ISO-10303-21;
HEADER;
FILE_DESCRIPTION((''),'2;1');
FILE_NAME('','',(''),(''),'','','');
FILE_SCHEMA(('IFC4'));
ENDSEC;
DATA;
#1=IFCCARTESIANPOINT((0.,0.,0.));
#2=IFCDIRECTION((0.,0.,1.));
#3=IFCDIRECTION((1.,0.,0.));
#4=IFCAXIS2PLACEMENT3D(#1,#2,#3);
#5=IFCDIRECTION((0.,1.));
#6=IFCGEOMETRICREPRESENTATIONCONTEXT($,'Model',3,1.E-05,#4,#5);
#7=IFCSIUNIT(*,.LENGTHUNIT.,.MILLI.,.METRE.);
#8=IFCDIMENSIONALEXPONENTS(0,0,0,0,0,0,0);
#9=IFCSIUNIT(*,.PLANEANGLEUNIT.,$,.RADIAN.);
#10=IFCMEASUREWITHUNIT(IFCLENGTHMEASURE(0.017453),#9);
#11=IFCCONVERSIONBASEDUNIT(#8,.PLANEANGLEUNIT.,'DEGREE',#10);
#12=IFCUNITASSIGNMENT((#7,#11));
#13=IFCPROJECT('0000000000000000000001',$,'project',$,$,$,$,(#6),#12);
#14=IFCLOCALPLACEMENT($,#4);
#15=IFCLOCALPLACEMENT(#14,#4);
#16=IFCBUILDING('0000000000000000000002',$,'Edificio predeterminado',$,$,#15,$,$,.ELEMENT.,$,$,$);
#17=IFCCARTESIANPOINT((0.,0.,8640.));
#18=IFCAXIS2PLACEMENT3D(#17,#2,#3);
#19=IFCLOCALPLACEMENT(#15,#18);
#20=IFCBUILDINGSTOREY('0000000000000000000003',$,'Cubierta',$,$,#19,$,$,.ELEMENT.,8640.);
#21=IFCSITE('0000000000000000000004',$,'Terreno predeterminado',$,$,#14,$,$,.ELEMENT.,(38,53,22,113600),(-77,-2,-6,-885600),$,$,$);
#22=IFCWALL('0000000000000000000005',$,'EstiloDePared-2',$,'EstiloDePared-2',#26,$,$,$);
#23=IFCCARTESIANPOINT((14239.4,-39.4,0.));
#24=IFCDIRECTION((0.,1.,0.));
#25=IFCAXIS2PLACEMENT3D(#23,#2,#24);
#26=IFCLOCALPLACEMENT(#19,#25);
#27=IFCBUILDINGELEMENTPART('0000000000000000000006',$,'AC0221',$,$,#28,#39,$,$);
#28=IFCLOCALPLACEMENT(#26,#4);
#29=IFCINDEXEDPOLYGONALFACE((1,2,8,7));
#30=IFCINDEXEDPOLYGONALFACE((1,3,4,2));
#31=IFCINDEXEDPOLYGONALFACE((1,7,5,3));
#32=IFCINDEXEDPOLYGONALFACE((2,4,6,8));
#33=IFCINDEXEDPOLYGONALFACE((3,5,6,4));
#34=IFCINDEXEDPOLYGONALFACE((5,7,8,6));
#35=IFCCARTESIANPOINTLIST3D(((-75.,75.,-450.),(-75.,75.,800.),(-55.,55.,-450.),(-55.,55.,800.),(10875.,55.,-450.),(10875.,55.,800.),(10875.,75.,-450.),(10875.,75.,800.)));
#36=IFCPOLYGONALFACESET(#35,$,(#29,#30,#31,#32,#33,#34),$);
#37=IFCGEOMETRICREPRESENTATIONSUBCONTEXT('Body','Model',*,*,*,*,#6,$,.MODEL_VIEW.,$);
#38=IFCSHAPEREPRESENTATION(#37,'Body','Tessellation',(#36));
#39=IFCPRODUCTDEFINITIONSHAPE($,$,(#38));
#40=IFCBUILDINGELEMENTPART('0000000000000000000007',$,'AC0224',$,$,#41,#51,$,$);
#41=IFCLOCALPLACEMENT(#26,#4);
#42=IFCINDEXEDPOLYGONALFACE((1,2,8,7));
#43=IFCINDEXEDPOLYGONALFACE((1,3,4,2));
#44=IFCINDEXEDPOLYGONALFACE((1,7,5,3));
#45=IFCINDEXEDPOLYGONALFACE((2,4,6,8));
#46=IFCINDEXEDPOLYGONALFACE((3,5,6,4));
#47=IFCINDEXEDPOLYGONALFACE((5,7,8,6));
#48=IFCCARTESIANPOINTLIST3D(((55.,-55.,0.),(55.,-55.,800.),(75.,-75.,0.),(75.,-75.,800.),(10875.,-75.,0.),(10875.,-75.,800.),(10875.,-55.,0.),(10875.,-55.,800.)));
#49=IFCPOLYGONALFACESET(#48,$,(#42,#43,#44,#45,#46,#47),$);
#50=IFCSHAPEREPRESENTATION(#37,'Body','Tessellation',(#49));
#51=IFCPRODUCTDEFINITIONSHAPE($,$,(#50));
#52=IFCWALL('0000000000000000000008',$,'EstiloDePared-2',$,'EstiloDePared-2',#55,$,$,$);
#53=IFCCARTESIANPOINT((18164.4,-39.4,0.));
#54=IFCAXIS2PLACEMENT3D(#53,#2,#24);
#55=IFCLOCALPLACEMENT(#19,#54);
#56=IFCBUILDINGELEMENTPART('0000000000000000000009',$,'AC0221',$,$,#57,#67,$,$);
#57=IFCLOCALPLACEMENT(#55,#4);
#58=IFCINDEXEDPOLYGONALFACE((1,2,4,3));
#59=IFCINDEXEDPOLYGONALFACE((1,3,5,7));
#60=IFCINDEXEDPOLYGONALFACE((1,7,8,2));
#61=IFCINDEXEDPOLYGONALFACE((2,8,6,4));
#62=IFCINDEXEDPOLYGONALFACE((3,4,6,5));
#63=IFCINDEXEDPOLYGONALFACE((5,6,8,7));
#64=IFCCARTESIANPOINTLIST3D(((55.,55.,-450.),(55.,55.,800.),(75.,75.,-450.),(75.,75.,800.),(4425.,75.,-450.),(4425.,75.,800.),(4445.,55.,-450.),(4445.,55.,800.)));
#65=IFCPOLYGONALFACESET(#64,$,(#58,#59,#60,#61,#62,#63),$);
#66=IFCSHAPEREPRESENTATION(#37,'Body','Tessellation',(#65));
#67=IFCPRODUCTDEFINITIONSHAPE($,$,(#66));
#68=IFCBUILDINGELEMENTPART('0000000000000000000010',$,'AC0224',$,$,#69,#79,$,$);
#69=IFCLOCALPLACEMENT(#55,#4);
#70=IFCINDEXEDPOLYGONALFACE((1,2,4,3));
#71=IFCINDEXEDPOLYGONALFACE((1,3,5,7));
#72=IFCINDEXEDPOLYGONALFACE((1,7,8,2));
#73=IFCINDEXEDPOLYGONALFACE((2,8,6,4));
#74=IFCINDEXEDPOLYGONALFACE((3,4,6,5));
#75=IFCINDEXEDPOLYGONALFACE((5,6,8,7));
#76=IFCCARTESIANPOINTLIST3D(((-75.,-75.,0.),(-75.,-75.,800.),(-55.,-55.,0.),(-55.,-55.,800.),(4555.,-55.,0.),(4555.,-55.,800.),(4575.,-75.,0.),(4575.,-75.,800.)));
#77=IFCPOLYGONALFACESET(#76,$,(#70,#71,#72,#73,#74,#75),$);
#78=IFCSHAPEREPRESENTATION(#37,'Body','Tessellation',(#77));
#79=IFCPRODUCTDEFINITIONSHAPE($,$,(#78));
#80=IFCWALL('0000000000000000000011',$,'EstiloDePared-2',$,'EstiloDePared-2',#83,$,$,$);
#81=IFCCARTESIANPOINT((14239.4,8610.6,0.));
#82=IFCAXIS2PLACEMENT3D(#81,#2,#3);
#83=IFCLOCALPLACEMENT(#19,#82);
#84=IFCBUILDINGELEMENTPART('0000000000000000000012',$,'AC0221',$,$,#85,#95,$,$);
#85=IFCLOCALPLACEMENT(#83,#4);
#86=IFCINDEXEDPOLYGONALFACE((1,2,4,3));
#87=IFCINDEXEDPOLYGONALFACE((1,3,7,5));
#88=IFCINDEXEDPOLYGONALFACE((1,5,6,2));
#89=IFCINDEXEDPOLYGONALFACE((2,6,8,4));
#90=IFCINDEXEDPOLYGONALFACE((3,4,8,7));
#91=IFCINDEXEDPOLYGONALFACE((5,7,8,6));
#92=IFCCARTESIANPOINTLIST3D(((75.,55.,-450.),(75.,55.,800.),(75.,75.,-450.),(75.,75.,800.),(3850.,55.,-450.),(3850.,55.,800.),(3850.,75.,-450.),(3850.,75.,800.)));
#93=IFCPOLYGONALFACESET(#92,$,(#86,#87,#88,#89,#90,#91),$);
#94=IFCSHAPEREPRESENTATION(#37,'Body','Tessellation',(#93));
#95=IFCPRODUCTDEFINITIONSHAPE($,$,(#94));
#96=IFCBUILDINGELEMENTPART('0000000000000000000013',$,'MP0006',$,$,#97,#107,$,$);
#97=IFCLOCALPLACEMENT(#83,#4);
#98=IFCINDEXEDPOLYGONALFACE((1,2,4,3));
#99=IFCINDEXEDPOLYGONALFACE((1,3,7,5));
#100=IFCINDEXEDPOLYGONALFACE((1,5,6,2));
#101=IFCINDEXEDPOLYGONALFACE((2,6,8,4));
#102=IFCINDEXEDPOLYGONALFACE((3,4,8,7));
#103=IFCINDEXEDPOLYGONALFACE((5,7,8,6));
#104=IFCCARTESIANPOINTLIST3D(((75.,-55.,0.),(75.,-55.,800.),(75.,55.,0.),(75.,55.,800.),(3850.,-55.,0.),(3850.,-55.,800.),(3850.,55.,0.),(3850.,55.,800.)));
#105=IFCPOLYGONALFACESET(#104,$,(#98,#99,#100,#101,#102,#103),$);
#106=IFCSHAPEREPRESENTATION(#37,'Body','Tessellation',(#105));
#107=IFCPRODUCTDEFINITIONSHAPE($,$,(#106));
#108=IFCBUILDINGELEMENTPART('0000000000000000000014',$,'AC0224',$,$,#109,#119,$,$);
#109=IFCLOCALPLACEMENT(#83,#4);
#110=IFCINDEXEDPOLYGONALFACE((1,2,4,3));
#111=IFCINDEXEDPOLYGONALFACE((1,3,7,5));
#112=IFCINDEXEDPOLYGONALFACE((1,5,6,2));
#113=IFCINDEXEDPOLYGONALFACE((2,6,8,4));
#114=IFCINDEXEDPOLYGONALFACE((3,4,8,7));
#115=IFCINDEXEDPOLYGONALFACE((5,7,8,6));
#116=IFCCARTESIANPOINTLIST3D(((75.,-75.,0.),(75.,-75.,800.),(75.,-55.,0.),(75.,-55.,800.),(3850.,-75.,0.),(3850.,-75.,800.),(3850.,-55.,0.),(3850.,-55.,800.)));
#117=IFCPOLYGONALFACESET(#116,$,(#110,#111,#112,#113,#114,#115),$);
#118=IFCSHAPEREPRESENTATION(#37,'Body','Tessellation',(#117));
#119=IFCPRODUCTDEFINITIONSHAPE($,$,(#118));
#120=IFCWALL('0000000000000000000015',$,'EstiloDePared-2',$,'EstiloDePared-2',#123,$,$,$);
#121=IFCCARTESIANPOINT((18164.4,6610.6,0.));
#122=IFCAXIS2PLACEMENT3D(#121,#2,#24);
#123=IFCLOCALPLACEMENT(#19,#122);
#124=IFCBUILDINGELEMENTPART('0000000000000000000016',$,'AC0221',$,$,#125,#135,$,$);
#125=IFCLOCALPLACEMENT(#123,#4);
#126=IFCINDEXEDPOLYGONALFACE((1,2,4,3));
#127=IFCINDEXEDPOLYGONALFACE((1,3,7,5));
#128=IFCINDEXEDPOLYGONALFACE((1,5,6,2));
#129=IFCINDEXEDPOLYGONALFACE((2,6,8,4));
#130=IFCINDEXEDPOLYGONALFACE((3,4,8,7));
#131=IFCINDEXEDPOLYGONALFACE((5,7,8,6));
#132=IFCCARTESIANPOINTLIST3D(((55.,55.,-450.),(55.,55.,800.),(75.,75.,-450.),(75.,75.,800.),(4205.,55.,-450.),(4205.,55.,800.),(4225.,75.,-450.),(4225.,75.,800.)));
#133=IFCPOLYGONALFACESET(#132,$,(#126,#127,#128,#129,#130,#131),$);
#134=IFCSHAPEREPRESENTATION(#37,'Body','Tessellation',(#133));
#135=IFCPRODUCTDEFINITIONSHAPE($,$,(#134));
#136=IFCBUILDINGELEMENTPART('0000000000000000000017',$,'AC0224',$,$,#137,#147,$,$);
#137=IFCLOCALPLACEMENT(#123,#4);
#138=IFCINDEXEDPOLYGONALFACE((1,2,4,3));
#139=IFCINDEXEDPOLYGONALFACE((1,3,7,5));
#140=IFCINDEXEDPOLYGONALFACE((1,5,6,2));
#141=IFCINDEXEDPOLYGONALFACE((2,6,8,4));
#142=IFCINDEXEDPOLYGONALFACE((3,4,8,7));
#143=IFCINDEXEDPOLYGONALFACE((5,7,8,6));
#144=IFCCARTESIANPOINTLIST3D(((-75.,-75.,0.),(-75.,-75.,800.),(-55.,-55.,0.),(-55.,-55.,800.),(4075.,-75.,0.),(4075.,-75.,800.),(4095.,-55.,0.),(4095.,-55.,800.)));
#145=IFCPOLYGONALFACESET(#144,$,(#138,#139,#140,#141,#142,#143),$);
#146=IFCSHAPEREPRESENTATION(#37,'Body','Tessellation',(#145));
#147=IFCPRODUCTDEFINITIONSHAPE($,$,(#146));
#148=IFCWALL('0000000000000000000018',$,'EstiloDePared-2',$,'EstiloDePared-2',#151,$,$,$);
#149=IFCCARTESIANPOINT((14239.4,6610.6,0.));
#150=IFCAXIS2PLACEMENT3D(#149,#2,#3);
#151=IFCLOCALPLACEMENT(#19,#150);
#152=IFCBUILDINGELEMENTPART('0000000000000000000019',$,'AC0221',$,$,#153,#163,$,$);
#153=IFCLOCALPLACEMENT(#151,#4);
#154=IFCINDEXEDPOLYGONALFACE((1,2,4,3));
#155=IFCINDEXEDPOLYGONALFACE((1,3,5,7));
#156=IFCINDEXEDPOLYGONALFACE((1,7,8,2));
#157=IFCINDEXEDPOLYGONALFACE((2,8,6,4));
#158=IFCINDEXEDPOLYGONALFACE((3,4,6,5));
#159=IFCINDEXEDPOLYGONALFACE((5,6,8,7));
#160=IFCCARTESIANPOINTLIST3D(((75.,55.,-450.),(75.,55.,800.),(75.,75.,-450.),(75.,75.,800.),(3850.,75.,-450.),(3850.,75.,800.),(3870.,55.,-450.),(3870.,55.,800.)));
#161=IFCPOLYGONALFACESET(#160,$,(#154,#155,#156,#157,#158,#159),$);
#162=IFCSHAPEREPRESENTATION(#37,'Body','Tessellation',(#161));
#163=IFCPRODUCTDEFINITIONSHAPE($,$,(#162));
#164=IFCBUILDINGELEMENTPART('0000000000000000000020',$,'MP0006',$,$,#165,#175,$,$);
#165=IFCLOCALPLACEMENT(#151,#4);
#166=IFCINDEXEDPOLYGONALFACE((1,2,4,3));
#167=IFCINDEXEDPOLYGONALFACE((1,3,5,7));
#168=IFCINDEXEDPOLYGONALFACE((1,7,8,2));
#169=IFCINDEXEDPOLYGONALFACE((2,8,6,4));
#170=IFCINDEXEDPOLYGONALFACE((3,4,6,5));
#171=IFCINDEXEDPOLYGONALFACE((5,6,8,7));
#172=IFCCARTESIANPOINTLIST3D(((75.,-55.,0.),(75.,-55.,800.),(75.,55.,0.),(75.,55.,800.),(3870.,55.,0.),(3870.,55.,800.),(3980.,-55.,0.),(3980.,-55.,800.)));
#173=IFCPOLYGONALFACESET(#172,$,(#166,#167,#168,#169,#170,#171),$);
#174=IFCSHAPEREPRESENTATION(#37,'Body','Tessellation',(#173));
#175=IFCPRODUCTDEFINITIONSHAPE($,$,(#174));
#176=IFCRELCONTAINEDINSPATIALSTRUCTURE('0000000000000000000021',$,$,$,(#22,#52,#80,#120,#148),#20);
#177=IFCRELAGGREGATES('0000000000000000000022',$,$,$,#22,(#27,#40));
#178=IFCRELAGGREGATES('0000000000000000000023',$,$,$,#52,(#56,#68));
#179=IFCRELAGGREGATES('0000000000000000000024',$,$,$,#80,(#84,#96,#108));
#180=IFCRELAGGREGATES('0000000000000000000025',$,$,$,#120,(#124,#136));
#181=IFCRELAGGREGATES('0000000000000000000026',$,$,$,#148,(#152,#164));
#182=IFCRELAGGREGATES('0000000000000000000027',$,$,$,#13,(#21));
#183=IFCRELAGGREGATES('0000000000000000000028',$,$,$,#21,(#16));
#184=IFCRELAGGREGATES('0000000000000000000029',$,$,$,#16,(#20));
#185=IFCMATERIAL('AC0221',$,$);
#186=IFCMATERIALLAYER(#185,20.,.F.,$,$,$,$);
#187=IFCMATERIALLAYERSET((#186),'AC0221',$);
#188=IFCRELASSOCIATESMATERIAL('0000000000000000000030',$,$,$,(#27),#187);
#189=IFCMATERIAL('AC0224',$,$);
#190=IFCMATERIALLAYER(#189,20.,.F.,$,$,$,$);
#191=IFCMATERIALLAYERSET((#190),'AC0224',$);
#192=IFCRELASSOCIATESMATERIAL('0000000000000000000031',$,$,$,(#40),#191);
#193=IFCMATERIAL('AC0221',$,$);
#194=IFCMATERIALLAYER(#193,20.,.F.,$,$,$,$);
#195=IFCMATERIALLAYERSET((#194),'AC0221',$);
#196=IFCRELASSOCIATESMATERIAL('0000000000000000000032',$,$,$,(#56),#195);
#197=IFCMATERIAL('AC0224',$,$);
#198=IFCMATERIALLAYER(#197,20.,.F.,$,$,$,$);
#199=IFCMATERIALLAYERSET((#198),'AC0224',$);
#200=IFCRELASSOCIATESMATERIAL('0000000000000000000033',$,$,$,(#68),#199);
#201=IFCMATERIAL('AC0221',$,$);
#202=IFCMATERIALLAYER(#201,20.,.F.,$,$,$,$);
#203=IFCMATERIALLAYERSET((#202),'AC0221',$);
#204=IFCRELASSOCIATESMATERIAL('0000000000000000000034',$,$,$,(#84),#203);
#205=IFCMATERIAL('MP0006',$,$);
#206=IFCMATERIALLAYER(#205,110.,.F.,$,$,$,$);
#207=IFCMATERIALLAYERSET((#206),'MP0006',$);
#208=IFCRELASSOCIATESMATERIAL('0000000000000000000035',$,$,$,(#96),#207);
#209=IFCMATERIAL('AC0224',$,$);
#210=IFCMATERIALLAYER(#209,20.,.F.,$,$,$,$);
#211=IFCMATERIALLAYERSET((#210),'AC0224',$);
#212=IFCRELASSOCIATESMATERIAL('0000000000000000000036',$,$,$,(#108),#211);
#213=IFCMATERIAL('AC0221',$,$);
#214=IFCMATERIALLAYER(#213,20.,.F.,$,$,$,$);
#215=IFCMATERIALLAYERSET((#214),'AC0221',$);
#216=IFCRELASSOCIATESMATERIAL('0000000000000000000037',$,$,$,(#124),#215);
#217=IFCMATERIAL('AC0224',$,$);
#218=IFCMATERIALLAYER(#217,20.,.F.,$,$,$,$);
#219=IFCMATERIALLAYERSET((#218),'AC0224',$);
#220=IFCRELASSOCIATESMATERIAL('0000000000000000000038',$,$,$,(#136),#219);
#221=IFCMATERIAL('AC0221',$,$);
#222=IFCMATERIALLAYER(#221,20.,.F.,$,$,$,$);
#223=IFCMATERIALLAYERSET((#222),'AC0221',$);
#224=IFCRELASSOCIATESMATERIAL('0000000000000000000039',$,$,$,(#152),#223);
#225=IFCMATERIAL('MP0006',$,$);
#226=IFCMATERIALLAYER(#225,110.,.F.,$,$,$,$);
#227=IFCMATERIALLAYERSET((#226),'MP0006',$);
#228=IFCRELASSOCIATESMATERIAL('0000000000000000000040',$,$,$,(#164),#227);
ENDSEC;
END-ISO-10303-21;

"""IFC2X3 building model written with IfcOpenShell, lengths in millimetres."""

from ifc_helpers import new_model, entity, si_unit, converted_unit, direction, frame, origin_with_axes, place, context, subcontext, project, spatial, polyline, outline, extrude, material, layer, layer_set, layer_usage, element, aggregate, save


model = new_model("IFC2X3")

# Units and contexts
model_context = context("Model", 3, precision=1e-05, world=origin_with_axes(), true_north=direction((0.0, 1.0)))
body_context = subcontext(model_context, "Body", "Model", "MODEL_VIEW")
ifc_project = project(units=[si_unit("LENGTHUNIT", "METRE", prefix="MILLI"), converted_unit("PLANEANGLEUNIT", "DEGREE", entity("IfcLengthMeasure", 0.017453), si_unit("PLANEANGLEUNIT", "RADIAN"), dimensions=[0, 0, 0, 0, 0, 0, 0])], contexts=[model_context])

# Site, building, storey
site_placement = place(None, origin_with_axes())
site = spatial("IfcSite", under=ifc_project, at=site_placement, Name="Terreno predeterminado", CompositionType="ELEMENT", RefLatitude=(38, 53, 22, 113600), RefLongitude=(-77, -2, -6, -885600))
building_placement = place(site_placement, origin_with_axes())
building = spatial("IfcBuilding", under=site, at=building_placement, Name="Edificio predeterminado", CompositionType="ELEMENT")
storey_placement = place(building_placement, frame((0.0, 0.0, 8640.0), z_axis=(0.0, 0.0, 1.0), x_axis=(1.0, 0.0, 0.0)))
storey = spatial("IfcBuildingStorey", under=building, at=storey_placement, Name="Cubierta", CompositionType="ELEMENT", Elevation=8640.0)

# Walls, building element parts
wall_1_placement = place(storey_placement, frame((14239.4, -39.4, 0.0), z_axis=(0.0, 0.0, 1.0), x_axis=(0.0, 1.0, 0.0)))
wall_1 = element("IfcWall", 1, at=wall_1_placement, inside=storey, Name="EstiloDePared-2", ObjectType="EstiloDePared-2")
ifc_material_1 = material(Name="AC0221")
ifc_layer_1 = layer(ifc_material_1, 20.0, ventilated=False)
ifc_layer_set_1 = layer_set([ifc_layer_1], Name="AC0221")
ifc_layer_usage_1 = layer_usage(ifc_layer_set_1, "AXIS2", "NEGATIVE", -75.0)
building_element_part_1_placement = place(wall_1_placement, origin_with_axes())
building_element_part_1 = element("IfcBuildingElementPart", 2, at=building_element_part_1_placement, material=ifc_layer_usage_1, Name="AC0221", context=body_context, shape_type="SweptSolid", body=[
    extrude(outline(polyline([(10875.0, 75.0), (10875.0, 55.0), (-55.0, 55.0), (-75.0, 75.0), (10875.0, 75.0)])), frame((0.0, 0.0, -450.0), z_axis=(0.0, 0.0, 1.0), x_axis=(1.0, 0.0, 0.0)), (0.0, 0.0, 1.0), 1250.0),
])
ifc_material_2 = material(Name="AC0224")
ifc_layer_2 = layer(ifc_material_2, 20.0, ventilated=False)
ifc_layer_set_2 = layer_set([ifc_layer_2], Name="AC0224")
ifc_layer_usage_2 = layer_usage(ifc_layer_set_2, "AXIS2", "NEGATIVE", 55.0)
building_element_part_2_placement = place(wall_1_placement, origin_with_axes())
building_element_part_2 = element("IfcBuildingElementPart", 3, at=building_element_part_2_placement, material=ifc_layer_usage_2, Name="AC0224", context=body_context, shape_type="SweptSolid", body=[
    extrude(outline(polyline([(10875.0, -55.0), (10875.0, -75.0), (75.0, -75.0), (55.0, -55.0), (10875.0, -55.0)])), origin_with_axes(), (0.0, 0.0, 1.0), 800.0),
])
aggregate(wall_1, [building_element_part_1, building_element_part_2])
wall_2_placement = place(storey_placement, frame((18164.4, -39.4, 0.0), z_axis=(0.0, 0.0, 1.0), x_axis=(0.0, 1.0, 0.0)))
wall_2 = element("IfcWall", 4, at=wall_2_placement, inside=storey, Name="EstiloDePared-2", ObjectType="EstiloDePared-2")
ifc_material_3 = material(Name="AC0221")
ifc_layer_3 = layer(ifc_material_3, 20.0, ventilated=False)
ifc_layer_set_3 = layer_set([ifc_layer_3], Name="AC0221")
ifc_layer_usage_3 = layer_usage(ifc_layer_set_3, "AXIS2", "NEGATIVE", -75.0)
building_element_part_3_placement = place(wall_2_placement, origin_with_axes())
building_element_part_3 = element("IfcBuildingElementPart", 5, at=building_element_part_3_placement, material=ifc_layer_usage_3, Name="AC0221", context=body_context, shape_type="SweptSolid", body=[
    extrude(outline(polyline([(4425.0, 75.0), (4445.0, 55.0), (55.0, 55.0), (75.0, 75.0), (4425.0, 75.0)])), frame((0.0, 0.0, -450.0), z_axis=(0.0, 0.0, 1.0), x_axis=(1.0, 0.0, 0.0)), (0.0, 0.0, 1.0), 1250.0),
])
ifc_material_4 = material(Name="AC0224")
ifc_layer_4 = layer(ifc_material_4, 20.0, ventilated=False)
ifc_layer_set_4 = layer_set([ifc_layer_4], Name="AC0224")
ifc_layer_usage_4 = layer_usage(ifc_layer_set_4, "AXIS2", "NEGATIVE", 55.0)
building_element_part_4_placement = place(wall_2_placement, origin_with_axes())
building_element_part_4 = element("IfcBuildingElementPart", 6, at=building_element_part_4_placement, material=ifc_layer_usage_4, Name="AC0224", context=body_context, shape_type="SweptSolid", body=[
    extrude(outline(polyline([(4555.0, -55.0), (4575.0, -75.0), (-75.0, -75.0), (-55.0, -55.0), (4555.0, -55.0)])), origin_with_axes(), (0.0, 0.0, 1.0), 800.0),
])
aggregate(wall_2, [building_element_part_3, building_element_part_4])
wall_3_placement = place(storey_placement, frame((14239.4, 8610.6, 0.0), z_axis=(0.0, 0.0, 1.0), x_axis=(1.0, 0.0, 0.0)))
wall_3 = element("IfcWall", 7, at=wall_3_placement, inside=storey, Name="EstiloDePared-2", ObjectType="EstiloDePared-2")
ifc_material_5 = material(Name="AC0221")
ifc_layer_5 = layer(ifc_material_5, 20.0, ventilated=False)
ifc_layer_set_5 = layer_set([ifc_layer_5], Name="AC0221")
ifc_layer_usage_5 = layer_usage(ifc_layer_set_5, "AXIS2", "NEGATIVE", -75.0)
building_element_part_5_placement = place(wall_3_placement, origin_with_axes())
building_element_part_5 = element("IfcBuildingElementPart", 8, at=building_element_part_5_placement, material=ifc_layer_usage_5, Name="AC0221", context=body_context, shape_type="SweptSolid", body=[
    extrude(outline(polyline([(3850.0, 75.0), (3850.0, 55.0), (75.0, 55.0), (75.0, 75.0), (3850.0, 75.0)])), frame((0.0, 0.0, -450.0), z_axis=(0.0, 0.0, 1.0), x_axis=(1.0, 0.0, 0.0)), (0.0, 0.0, 1.0), 1250.0),
])
ifc_material_6 = material(Name="MP0006")
ifc_layer_6 = layer(ifc_material_6, 110.0, ventilated=False)
ifc_layer_set_6 = layer_set([ifc_layer_6], Name="MP0006")
ifc_layer_usage_6 = layer_usage(ifc_layer_set_6, "AXIS2", "NEGATIVE", -55.0)
building_element_part_6_placement = place(wall_3_placement, origin_with_axes())
building_element_part_6 = element("IfcBuildingElementPart", 9, at=building_element_part_6_placement, material=ifc_layer_usage_6, Name="MP0006", context=body_context, shape_type="SweptSolid", body=[
    extrude(outline(polyline([(3850.0, 55.0), (3850.0, -55.0), (75.0, -55.0), (75.0, 55.0), (3850.0, 55.0)])), origin_with_axes(), (0.0, 0.0, 1.0), 800.0),
])
ifc_material_7 = material(Name="AC0224")
ifc_layer_7 = layer(ifc_material_7, 20.0, ventilated=False)
ifc_layer_set_7 = layer_set([ifc_layer_7], Name="AC0224")
ifc_layer_usage_7 = layer_usage(ifc_layer_set_7, "AXIS2", "NEGATIVE", 55.0)
building_element_part_7_placement = place(wall_3_placement, origin_with_axes())
building_element_part_7 = element("IfcBuildingElementPart", 10, at=building_element_part_7_placement, material=ifc_layer_usage_7, Name="AC0224", context=body_context, shape_type="SweptSolid", body=[
    extrude(outline(polyline([(3850.0, -55.0), (3850.0, -75.0), (75.0, -75.0), (75.0, -55.0), (3850.0, -55.0)])), origin_with_axes(), (0.0, 0.0, 1.0), 800.0),
])
aggregate(wall_3, [building_element_part_5, building_element_part_6, building_element_part_7])
wall_4_placement = place(storey_placement, frame((18164.4, 6610.6, 0.0), z_axis=(0.0, 0.0, 1.0), x_axis=(0.0, 1.0, 0.0)))
wall_4 = element("IfcWall", 11, at=wall_4_placement, inside=storey, Name="EstiloDePared-2", ObjectType="EstiloDePared-2")
ifc_material_8 = material(Name="AC0221")
ifc_layer_8 = layer(ifc_material_8, 20.0, ventilated=False)
ifc_layer_set_8 = layer_set([ifc_layer_8], Name="AC0221")
ifc_layer_usage_8 = layer_usage(ifc_layer_set_8, "AXIS2", "NEGATIVE", -75.0)
building_element_part_8_placement = place(wall_4_placement, origin_with_axes())
building_element_part_8 = element("IfcBuildingElementPart", 12, at=building_element_part_8_placement, material=ifc_layer_usage_8, Name="AC0221", context=body_context, shape_type="SweptSolid", body=[
    extrude(outline(polyline([(4225.0, 75.0), (4205.0, 55.0), (55.0, 55.0), (75.0, 75.0), (4225.0, 75.0)])), frame((0.0, 0.0, -450.0), z_axis=(0.0, 0.0, 1.0), x_axis=(1.0, 0.0, 0.0)), (0.0, 0.0, 1.0), 1250.0),
])
ifc_material_9 = material(Name="AC0224")
ifc_layer_9 = layer(ifc_material_9, 20.0, ventilated=False)
ifc_layer_set_9 = layer_set([ifc_layer_9], Name="AC0224")
ifc_layer_usage_9 = layer_usage(ifc_layer_set_9, "AXIS2", "NEGATIVE", 55.0)
building_element_part_9_placement = place(wall_4_placement, origin_with_axes())
building_element_part_9 = element("IfcBuildingElementPart", 13, at=building_element_part_9_placement, material=ifc_layer_usage_9, Name="AC0224", context=body_context, shape_type="SweptSolid", body=[
    extrude(outline(polyline([(4095.0, -55.0), (4075.0, -75.0), (-75.0, -75.0), (-55.0, -55.0), (4095.0, -55.0)])), origin_with_axes(), (0.0, 0.0, 1.0), 800.0),
])
aggregate(wall_4, [building_element_part_8, building_element_part_9])
wall_5_placement = place(storey_placement, frame((14239.4, 6610.6, 0.0), z_axis=(0.0, 0.0, 1.0), x_axis=(1.0, 0.0, 0.0)))
wall_5 = element("IfcWall", 14, at=wall_5_placement, inside=storey, Name="EstiloDePared-2", ObjectType="EstiloDePared-2")
ifc_material_10 = material(Name="AC0221")
ifc_layer_10 = layer(ifc_material_10, 20.0, ventilated=False)
ifc_layer_set_10 = layer_set([ifc_layer_10], Name="AC0221")
ifc_layer_usage_10 = layer_usage(ifc_layer_set_10, "AXIS2", "NEGATIVE", -75.0)
building_element_part_10_placement = place(wall_5_placement, origin_with_axes())
building_element_part_10 = element("IfcBuildingElementPart", 15, at=building_element_part_10_placement, material=ifc_layer_usage_10, Name="AC0221", context=body_context, shape_type="SweptSolid", body=[
    extrude(outline(polyline([(3850.0, 75.0), (3870.0, 55.0), (75.0, 55.0), (75.0, 75.0), (3850.0, 75.0)])), frame((0.0, 0.0, -450.0), z_axis=(0.0, 0.0, 1.0), x_axis=(1.0, 0.0, 0.0)), (0.0, 0.0, 1.0), 1250.0),
])
ifc_material_11 = material(Name="MP0006")
ifc_layer_11 = layer(ifc_material_11, 110.0, ventilated=False)
ifc_layer_set_11 = layer_set([ifc_layer_11], Name="MP0006")
ifc_layer_usage_11 = layer_usage(ifc_layer_set_11, "AXIS2", "NEGATIVE", -55.0)
building_element_part_11_placement = place(wall_5_placement, origin_with_axes())
building_element_part_11 = element("IfcBuildingElementPart", 16, at=building_element_part_11_placement, material=ifc_layer_usage_11, Name="MP0006", context=body_context, shape_type="SweptSolid", body=[
    extrude(outline(polyline([(3870.0, 55.0), (3980.0, -55.0), (75.0, -55.0), (75.0, 55.0), (3870.0, 55.0)])), origin_with_axes(), (0.0, 0.0, 1.0), 800.0),
])
aggregate(wall_5, [building_element_part_10, building_element_part_11])

save(model, "model.ifc")
